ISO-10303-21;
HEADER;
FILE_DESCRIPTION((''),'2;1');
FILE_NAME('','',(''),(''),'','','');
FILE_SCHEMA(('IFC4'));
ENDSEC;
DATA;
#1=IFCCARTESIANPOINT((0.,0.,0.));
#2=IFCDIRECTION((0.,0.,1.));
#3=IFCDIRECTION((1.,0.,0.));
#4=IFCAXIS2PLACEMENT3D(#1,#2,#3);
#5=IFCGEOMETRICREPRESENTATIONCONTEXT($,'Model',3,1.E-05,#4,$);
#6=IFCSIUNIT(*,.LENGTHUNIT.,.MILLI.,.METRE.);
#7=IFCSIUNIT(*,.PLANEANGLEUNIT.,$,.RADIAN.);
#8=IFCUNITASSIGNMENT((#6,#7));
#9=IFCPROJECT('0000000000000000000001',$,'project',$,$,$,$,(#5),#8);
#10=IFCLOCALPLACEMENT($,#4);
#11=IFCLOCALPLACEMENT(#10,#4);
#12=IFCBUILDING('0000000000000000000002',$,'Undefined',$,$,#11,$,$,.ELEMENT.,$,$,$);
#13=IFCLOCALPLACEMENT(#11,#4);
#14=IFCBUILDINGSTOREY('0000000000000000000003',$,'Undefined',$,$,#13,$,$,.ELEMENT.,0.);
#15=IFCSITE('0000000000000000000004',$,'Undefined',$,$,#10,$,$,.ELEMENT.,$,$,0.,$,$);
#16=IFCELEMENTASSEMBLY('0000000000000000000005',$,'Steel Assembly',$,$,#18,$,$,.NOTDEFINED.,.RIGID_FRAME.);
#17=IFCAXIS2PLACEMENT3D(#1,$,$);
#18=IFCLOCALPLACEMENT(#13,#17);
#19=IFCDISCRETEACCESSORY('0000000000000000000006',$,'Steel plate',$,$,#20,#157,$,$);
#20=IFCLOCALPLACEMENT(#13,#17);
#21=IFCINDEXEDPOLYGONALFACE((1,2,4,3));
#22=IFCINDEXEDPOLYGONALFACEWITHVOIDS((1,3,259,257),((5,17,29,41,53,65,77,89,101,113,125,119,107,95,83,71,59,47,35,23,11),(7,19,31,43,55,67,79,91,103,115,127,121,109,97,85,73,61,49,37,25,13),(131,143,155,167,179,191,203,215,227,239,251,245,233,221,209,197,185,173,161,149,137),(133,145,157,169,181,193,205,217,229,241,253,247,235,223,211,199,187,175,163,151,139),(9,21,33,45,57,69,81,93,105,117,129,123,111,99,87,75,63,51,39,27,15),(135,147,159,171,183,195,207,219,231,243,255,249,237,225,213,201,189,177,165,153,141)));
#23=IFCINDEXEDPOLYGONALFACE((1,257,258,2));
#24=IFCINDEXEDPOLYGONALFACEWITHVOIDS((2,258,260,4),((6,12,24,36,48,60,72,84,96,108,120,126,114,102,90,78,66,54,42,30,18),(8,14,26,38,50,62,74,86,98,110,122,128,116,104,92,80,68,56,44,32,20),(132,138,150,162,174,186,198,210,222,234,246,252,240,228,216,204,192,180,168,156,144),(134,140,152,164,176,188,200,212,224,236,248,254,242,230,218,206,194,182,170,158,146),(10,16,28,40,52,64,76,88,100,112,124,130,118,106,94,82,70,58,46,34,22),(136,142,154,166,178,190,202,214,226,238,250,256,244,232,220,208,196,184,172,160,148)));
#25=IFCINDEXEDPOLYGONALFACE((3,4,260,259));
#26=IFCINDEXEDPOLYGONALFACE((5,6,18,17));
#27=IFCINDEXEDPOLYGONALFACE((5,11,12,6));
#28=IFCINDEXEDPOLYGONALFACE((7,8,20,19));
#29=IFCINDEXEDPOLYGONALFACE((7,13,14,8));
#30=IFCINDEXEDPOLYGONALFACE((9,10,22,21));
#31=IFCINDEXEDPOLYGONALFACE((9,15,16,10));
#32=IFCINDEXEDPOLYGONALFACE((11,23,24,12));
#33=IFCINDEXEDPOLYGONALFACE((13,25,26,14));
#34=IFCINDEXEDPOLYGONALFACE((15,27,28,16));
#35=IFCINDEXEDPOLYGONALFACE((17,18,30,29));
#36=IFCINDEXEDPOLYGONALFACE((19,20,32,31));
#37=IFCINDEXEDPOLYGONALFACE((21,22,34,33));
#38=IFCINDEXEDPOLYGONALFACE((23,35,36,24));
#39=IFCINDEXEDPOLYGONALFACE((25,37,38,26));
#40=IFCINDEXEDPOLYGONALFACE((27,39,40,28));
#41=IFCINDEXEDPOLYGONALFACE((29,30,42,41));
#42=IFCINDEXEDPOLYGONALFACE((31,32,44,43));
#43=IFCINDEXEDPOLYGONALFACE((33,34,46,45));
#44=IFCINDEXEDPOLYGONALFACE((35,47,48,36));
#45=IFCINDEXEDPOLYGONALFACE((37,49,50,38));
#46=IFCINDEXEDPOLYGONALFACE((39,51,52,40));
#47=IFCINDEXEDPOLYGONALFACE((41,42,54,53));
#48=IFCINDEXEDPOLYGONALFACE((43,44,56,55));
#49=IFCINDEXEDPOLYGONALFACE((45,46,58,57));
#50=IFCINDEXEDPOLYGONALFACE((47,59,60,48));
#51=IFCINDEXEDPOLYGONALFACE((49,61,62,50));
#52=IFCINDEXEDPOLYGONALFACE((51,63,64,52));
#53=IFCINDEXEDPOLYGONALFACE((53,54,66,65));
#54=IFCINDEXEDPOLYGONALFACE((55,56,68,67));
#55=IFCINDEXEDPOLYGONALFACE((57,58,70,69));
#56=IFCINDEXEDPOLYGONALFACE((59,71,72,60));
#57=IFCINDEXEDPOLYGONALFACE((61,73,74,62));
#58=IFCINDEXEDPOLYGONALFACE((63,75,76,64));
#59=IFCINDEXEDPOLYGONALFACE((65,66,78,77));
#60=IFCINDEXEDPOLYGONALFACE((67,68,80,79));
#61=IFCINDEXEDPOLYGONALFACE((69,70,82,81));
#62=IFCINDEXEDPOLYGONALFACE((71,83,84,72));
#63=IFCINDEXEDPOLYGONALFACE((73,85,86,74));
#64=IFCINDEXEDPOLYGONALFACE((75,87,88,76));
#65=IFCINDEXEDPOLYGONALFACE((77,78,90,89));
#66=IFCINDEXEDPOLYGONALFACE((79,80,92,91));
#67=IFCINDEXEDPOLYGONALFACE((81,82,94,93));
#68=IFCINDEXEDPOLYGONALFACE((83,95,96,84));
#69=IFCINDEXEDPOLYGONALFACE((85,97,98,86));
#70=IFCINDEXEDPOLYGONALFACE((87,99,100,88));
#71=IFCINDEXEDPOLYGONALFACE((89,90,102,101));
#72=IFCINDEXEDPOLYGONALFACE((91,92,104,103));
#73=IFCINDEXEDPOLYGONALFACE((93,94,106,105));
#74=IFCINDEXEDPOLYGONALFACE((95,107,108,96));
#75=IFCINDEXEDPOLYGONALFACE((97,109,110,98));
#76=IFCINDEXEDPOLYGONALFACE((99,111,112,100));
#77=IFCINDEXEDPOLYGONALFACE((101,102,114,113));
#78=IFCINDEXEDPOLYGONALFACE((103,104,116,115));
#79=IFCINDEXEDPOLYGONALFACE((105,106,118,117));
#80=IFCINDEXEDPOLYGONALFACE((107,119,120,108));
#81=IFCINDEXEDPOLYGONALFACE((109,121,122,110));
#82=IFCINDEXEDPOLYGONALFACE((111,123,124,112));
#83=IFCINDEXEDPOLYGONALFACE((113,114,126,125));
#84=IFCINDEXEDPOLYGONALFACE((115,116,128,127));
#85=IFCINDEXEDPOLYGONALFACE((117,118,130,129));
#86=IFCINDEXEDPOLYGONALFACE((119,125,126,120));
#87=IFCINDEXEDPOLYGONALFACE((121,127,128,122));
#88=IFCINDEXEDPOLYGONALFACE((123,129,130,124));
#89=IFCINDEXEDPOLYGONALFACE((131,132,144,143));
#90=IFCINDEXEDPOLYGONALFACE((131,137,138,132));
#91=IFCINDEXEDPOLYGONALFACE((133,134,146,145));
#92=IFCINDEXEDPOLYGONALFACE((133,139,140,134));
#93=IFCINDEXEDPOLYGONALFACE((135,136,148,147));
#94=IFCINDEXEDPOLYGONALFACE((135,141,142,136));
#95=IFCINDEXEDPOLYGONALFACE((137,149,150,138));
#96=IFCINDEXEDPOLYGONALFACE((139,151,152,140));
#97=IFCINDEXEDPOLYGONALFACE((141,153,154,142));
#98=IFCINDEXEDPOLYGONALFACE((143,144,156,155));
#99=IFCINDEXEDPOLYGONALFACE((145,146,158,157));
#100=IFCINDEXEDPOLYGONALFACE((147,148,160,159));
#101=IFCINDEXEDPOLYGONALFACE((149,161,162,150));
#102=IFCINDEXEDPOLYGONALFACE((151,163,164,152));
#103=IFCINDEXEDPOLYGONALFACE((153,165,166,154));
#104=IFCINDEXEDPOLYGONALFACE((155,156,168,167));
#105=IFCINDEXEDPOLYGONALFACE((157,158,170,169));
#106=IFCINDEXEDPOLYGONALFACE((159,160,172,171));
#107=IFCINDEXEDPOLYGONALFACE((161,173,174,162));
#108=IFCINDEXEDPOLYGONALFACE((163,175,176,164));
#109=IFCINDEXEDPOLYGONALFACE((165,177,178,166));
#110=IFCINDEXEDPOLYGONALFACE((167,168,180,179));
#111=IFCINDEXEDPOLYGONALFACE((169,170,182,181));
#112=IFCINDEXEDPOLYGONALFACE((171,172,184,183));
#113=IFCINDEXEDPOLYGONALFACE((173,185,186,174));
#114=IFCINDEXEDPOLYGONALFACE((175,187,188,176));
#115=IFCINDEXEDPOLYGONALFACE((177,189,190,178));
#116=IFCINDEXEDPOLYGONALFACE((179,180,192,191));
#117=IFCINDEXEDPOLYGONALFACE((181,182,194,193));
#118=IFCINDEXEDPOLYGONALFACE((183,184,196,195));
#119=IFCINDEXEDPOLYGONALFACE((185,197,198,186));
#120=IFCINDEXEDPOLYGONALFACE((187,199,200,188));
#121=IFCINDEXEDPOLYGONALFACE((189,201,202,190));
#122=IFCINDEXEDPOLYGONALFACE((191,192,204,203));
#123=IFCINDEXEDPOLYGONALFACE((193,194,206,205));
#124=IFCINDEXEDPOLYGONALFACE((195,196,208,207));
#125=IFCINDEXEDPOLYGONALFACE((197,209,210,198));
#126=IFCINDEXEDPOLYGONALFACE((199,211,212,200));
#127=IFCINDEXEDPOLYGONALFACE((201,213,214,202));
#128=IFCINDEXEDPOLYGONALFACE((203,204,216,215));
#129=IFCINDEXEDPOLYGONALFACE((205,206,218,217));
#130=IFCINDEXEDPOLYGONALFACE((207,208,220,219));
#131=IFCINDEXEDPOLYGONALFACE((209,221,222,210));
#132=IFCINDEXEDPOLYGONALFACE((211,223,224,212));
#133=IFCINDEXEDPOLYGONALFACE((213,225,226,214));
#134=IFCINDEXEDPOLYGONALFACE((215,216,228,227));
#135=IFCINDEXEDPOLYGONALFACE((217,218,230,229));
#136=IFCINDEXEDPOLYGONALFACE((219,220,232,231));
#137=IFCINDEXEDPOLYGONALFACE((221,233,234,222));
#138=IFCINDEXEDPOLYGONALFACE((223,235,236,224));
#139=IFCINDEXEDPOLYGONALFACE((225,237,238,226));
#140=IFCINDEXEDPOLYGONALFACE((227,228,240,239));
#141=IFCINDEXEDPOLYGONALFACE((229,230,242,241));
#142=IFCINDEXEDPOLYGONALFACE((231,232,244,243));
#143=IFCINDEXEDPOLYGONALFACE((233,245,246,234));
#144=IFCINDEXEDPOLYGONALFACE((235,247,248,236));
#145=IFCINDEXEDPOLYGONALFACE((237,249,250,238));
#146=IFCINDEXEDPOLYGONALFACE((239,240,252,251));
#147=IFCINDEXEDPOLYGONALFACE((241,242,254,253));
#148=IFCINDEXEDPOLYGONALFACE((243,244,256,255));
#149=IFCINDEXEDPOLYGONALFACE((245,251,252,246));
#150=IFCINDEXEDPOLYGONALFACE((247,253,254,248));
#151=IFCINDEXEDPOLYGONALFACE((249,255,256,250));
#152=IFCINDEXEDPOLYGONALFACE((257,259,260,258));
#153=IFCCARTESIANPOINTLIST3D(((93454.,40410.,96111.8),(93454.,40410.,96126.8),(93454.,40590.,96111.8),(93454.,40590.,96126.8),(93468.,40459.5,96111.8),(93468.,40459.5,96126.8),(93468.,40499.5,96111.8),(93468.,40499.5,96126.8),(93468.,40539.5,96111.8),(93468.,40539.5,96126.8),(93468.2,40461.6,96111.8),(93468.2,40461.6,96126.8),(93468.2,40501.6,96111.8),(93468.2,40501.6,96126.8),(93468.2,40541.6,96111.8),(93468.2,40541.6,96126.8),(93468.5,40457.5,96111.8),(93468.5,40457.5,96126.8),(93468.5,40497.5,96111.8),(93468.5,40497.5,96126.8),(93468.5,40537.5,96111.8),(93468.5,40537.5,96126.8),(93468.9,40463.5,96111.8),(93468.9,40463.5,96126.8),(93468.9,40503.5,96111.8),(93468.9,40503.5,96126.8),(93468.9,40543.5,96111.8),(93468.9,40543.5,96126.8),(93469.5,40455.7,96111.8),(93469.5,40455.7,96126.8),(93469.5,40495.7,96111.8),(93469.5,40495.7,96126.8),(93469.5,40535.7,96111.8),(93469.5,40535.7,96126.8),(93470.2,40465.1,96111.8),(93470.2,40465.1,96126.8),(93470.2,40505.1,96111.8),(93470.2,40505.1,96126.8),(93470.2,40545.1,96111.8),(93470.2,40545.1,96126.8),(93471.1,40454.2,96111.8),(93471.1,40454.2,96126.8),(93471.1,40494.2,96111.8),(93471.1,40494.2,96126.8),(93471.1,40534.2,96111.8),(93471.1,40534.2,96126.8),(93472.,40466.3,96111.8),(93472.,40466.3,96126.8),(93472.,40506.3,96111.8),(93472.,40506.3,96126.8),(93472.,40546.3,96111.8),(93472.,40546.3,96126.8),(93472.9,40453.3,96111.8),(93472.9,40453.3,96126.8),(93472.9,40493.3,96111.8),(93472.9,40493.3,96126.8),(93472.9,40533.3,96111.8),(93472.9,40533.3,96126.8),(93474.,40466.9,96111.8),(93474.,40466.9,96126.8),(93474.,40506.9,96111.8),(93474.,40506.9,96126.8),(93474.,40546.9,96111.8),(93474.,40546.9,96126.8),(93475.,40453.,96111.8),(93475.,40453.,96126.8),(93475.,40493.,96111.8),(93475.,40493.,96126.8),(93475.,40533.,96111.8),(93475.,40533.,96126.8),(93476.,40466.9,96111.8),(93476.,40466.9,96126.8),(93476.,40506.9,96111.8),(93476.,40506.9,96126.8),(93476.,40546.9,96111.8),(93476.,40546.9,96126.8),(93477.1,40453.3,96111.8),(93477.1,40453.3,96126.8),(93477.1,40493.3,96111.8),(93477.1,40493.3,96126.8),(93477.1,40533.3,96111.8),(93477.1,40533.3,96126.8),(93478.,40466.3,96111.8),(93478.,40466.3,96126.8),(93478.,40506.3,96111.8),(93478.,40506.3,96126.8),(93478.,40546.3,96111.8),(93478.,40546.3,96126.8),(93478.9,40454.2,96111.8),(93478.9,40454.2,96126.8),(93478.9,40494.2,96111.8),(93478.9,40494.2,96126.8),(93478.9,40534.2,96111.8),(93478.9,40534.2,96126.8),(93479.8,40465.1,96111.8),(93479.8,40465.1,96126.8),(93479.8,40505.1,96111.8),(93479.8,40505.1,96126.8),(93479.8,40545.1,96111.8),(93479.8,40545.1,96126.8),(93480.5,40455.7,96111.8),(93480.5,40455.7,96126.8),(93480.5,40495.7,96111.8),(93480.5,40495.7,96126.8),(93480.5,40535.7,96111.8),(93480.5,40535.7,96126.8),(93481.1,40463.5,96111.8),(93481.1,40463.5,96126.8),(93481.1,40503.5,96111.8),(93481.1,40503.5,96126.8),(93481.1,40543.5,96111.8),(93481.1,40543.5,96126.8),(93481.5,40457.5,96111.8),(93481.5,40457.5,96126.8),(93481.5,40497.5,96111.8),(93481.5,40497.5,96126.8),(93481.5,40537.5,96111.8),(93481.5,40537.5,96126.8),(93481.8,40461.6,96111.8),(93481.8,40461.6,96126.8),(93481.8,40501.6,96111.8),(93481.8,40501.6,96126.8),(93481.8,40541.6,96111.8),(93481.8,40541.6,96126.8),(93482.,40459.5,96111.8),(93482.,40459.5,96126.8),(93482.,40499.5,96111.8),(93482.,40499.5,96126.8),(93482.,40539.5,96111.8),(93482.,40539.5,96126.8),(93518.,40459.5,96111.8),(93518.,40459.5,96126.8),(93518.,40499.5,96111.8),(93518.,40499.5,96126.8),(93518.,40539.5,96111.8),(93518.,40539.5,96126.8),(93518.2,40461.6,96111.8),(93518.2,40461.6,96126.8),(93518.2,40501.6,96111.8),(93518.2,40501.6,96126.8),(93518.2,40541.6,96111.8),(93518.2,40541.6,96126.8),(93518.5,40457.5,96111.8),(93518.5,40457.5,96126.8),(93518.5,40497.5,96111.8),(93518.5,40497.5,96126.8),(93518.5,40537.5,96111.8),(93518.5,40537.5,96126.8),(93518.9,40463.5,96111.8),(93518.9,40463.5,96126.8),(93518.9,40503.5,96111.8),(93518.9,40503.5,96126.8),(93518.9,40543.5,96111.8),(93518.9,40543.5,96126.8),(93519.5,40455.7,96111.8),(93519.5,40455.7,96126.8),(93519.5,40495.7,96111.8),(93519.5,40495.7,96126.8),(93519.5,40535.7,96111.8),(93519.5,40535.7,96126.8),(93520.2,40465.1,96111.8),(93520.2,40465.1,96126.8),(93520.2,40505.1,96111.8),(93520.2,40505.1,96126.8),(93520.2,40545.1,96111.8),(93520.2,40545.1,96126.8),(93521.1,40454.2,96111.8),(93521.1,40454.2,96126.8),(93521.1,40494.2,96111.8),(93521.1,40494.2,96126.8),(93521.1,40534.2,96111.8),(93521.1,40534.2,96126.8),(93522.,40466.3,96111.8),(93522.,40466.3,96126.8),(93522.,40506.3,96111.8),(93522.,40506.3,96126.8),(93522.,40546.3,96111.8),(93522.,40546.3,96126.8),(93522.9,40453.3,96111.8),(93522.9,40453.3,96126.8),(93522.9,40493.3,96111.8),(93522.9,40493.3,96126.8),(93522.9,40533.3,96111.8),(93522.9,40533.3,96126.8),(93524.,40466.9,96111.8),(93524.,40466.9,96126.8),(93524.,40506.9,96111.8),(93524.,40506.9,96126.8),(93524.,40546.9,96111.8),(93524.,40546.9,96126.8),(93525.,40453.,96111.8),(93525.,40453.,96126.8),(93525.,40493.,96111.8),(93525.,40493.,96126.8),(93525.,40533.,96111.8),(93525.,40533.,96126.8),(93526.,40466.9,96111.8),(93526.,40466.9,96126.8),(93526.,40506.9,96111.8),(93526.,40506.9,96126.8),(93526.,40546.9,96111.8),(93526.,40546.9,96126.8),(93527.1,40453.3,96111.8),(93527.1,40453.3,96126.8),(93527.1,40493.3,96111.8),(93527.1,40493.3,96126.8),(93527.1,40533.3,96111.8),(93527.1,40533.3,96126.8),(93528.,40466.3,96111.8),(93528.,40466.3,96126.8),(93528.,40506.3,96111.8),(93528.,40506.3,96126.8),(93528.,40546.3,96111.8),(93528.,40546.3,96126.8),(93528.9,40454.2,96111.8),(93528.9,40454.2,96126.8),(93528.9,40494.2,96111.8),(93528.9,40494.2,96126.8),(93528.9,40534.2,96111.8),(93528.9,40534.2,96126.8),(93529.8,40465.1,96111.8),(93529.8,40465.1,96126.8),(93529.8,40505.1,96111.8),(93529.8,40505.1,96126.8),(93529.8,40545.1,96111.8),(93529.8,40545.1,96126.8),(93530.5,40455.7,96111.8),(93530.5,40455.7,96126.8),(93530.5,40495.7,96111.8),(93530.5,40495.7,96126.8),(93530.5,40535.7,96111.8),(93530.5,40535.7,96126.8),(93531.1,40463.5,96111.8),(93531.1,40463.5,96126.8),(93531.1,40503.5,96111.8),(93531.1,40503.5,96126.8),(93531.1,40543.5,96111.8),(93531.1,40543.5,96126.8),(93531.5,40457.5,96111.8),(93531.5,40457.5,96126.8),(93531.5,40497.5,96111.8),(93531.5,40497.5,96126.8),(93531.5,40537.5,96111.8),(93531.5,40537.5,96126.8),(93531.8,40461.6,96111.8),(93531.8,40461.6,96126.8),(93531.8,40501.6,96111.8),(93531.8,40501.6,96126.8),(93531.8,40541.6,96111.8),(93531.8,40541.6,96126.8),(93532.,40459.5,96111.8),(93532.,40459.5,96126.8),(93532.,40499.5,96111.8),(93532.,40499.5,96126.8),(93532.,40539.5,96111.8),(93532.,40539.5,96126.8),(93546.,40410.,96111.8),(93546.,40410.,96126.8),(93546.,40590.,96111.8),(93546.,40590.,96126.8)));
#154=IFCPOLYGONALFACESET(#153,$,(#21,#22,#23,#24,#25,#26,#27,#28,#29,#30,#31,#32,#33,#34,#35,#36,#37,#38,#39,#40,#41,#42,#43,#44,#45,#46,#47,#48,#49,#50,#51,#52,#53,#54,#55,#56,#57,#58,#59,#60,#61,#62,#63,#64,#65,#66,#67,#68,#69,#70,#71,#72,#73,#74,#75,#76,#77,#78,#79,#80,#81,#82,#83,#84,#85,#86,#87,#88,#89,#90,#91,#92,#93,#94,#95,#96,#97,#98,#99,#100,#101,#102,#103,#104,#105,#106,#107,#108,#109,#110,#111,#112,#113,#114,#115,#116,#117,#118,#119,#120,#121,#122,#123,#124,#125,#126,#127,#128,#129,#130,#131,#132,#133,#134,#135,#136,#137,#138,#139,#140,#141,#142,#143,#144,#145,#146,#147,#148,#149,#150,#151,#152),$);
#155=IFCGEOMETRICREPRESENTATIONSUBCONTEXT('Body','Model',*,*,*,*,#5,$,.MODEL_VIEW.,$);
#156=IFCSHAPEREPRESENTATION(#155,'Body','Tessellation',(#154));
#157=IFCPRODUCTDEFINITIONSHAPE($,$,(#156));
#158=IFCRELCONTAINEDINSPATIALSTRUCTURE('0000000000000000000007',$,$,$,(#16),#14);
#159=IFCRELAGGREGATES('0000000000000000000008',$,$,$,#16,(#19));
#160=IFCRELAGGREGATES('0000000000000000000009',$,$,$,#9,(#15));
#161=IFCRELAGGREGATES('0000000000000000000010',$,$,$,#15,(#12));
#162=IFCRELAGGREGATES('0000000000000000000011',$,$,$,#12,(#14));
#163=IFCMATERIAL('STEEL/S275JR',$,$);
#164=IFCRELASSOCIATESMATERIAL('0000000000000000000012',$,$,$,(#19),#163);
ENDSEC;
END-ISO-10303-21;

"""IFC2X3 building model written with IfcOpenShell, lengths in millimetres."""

from ifc_helpers import new_model, si_unit, frame, origin_with_axes, origin_2d_with_axis, place, context, subcontext, project, spatial, polyline, circle, outline, extrude, source, transform, mapped, material, element, aggregate, save


model = new_model("IFC2X3")

# Units and contexts
model_context = context("Model", 3, precision=1e-05, world=origin_with_axes())
body_context = subcontext(model_context, "Body", "Model", "MODEL_VIEW")
ifc_project = project(units=[si_unit("LENGTHUNIT", "METRE", prefix="MILLI"), si_unit("PLANEANGLEUNIT", "RADIAN")], contexts=[model_context])

# Site, building, storey
site_placement = place(None, origin_with_axes())
site = spatial("IfcSite", under=ifc_project, at=site_placement, Name="Undefined", CompositionType="ELEMENT", RefElevation=0.0)
building_placement = place(site_placement, origin_with_axes())
building = spatial("IfcBuilding", under=site, at=building_placement, Name="Undefined", CompositionType="ELEMENT")
storey_placement = place(building_placement, origin_with_axes())
storey = spatial("IfcBuildingStorey", under=building, at=storey_placement, Name="Undefined", CompositionType="ELEMENT", Elevation=0.0)

# Shared definitions
ifc_material_1 = material(Name="STEEL/S275JR")

# Element assembly
assembly_1_placement = place(storey_placement, origin_with_axes())
assembly_1 = element("IfcElementAssembly", 1, at=assembly_1_placement, inside=storey, Name="Steel Assembly", AssemblyPlace="NOTDEFINED", PredefinedType="RIGID_FRAME")

# Discrete accessory, opening
discrete_accessory_1_placement = place(assembly_1_placement, frame((93546.0, 40410.0, 96119.3), z_axis=(0.0, 0.0, 1.0), x_axis=(0.0, 1.0, 0.0)))
discrete_accessory_1 = element("IfcDiscreteAccessory", 2, at=discrete_accessory_1_placement, material=ifc_material_1, Name="Steel plate", context=body_context, shape_type="SweptSolid", body=[
    extrude(outline(polyline([(0.0, 0.0), (180.0, 0.0), (180.0, 92.0), (0.0, 92.0), (0.0, 0.0)])), frame((0.0, 0.0, -7.5), z_axis=(0.0, 0.0, 1.0), x_axis=(1.0, 0.0, 0.0)), (0.0, 0.0, 1.0), 15.0),
])
shared_shape_1 = source(origin_with_axes(), body_context, "Body", "SweptSolid", [
    extrude(circle(Radius=7.0, at=origin_2d_with_axis()), frame((0.0, -0.1, 0.0), z_axis=(0.0, 1.0, 0.0), x_axis=(1.0, 0.0, 0.0)), (0.0, 0.0, 1.0), 15.2),
])
opening_1_placement = place(assembly_1_placement, frame((93500.0, 40540.0, 96126.8), z_axis=(1.0, 0.0, 0.0), x_axis=(0.0, -1.0, 0.0)))
element("IfcOpeningElement", 3, at=opening_1_placement, cuts=discrete_accessory_1, ObjectType="Opening", context=body_context, shape_type="MappedRepresentation", body=[
    mapped(shared_shape_1, transform((0.0, 0.0, -25.0))),
    mapped(shared_shape_1, transform((40.0, 0.0, -25.0))),
    mapped(shared_shape_1, transform((80.0, 0.0, -25.0))),
    mapped(shared_shape_1, transform((0.0, 0.0, 25.0))),
    mapped(shared_shape_1, transform((40.0, 0.0, 25.0))),
    mapped(shared_shape_1, transform((80.0, 0.0, 25.0))),
])

aggregate(assembly_1, [discrete_accessory_1])

save(model, "model.ifc")
